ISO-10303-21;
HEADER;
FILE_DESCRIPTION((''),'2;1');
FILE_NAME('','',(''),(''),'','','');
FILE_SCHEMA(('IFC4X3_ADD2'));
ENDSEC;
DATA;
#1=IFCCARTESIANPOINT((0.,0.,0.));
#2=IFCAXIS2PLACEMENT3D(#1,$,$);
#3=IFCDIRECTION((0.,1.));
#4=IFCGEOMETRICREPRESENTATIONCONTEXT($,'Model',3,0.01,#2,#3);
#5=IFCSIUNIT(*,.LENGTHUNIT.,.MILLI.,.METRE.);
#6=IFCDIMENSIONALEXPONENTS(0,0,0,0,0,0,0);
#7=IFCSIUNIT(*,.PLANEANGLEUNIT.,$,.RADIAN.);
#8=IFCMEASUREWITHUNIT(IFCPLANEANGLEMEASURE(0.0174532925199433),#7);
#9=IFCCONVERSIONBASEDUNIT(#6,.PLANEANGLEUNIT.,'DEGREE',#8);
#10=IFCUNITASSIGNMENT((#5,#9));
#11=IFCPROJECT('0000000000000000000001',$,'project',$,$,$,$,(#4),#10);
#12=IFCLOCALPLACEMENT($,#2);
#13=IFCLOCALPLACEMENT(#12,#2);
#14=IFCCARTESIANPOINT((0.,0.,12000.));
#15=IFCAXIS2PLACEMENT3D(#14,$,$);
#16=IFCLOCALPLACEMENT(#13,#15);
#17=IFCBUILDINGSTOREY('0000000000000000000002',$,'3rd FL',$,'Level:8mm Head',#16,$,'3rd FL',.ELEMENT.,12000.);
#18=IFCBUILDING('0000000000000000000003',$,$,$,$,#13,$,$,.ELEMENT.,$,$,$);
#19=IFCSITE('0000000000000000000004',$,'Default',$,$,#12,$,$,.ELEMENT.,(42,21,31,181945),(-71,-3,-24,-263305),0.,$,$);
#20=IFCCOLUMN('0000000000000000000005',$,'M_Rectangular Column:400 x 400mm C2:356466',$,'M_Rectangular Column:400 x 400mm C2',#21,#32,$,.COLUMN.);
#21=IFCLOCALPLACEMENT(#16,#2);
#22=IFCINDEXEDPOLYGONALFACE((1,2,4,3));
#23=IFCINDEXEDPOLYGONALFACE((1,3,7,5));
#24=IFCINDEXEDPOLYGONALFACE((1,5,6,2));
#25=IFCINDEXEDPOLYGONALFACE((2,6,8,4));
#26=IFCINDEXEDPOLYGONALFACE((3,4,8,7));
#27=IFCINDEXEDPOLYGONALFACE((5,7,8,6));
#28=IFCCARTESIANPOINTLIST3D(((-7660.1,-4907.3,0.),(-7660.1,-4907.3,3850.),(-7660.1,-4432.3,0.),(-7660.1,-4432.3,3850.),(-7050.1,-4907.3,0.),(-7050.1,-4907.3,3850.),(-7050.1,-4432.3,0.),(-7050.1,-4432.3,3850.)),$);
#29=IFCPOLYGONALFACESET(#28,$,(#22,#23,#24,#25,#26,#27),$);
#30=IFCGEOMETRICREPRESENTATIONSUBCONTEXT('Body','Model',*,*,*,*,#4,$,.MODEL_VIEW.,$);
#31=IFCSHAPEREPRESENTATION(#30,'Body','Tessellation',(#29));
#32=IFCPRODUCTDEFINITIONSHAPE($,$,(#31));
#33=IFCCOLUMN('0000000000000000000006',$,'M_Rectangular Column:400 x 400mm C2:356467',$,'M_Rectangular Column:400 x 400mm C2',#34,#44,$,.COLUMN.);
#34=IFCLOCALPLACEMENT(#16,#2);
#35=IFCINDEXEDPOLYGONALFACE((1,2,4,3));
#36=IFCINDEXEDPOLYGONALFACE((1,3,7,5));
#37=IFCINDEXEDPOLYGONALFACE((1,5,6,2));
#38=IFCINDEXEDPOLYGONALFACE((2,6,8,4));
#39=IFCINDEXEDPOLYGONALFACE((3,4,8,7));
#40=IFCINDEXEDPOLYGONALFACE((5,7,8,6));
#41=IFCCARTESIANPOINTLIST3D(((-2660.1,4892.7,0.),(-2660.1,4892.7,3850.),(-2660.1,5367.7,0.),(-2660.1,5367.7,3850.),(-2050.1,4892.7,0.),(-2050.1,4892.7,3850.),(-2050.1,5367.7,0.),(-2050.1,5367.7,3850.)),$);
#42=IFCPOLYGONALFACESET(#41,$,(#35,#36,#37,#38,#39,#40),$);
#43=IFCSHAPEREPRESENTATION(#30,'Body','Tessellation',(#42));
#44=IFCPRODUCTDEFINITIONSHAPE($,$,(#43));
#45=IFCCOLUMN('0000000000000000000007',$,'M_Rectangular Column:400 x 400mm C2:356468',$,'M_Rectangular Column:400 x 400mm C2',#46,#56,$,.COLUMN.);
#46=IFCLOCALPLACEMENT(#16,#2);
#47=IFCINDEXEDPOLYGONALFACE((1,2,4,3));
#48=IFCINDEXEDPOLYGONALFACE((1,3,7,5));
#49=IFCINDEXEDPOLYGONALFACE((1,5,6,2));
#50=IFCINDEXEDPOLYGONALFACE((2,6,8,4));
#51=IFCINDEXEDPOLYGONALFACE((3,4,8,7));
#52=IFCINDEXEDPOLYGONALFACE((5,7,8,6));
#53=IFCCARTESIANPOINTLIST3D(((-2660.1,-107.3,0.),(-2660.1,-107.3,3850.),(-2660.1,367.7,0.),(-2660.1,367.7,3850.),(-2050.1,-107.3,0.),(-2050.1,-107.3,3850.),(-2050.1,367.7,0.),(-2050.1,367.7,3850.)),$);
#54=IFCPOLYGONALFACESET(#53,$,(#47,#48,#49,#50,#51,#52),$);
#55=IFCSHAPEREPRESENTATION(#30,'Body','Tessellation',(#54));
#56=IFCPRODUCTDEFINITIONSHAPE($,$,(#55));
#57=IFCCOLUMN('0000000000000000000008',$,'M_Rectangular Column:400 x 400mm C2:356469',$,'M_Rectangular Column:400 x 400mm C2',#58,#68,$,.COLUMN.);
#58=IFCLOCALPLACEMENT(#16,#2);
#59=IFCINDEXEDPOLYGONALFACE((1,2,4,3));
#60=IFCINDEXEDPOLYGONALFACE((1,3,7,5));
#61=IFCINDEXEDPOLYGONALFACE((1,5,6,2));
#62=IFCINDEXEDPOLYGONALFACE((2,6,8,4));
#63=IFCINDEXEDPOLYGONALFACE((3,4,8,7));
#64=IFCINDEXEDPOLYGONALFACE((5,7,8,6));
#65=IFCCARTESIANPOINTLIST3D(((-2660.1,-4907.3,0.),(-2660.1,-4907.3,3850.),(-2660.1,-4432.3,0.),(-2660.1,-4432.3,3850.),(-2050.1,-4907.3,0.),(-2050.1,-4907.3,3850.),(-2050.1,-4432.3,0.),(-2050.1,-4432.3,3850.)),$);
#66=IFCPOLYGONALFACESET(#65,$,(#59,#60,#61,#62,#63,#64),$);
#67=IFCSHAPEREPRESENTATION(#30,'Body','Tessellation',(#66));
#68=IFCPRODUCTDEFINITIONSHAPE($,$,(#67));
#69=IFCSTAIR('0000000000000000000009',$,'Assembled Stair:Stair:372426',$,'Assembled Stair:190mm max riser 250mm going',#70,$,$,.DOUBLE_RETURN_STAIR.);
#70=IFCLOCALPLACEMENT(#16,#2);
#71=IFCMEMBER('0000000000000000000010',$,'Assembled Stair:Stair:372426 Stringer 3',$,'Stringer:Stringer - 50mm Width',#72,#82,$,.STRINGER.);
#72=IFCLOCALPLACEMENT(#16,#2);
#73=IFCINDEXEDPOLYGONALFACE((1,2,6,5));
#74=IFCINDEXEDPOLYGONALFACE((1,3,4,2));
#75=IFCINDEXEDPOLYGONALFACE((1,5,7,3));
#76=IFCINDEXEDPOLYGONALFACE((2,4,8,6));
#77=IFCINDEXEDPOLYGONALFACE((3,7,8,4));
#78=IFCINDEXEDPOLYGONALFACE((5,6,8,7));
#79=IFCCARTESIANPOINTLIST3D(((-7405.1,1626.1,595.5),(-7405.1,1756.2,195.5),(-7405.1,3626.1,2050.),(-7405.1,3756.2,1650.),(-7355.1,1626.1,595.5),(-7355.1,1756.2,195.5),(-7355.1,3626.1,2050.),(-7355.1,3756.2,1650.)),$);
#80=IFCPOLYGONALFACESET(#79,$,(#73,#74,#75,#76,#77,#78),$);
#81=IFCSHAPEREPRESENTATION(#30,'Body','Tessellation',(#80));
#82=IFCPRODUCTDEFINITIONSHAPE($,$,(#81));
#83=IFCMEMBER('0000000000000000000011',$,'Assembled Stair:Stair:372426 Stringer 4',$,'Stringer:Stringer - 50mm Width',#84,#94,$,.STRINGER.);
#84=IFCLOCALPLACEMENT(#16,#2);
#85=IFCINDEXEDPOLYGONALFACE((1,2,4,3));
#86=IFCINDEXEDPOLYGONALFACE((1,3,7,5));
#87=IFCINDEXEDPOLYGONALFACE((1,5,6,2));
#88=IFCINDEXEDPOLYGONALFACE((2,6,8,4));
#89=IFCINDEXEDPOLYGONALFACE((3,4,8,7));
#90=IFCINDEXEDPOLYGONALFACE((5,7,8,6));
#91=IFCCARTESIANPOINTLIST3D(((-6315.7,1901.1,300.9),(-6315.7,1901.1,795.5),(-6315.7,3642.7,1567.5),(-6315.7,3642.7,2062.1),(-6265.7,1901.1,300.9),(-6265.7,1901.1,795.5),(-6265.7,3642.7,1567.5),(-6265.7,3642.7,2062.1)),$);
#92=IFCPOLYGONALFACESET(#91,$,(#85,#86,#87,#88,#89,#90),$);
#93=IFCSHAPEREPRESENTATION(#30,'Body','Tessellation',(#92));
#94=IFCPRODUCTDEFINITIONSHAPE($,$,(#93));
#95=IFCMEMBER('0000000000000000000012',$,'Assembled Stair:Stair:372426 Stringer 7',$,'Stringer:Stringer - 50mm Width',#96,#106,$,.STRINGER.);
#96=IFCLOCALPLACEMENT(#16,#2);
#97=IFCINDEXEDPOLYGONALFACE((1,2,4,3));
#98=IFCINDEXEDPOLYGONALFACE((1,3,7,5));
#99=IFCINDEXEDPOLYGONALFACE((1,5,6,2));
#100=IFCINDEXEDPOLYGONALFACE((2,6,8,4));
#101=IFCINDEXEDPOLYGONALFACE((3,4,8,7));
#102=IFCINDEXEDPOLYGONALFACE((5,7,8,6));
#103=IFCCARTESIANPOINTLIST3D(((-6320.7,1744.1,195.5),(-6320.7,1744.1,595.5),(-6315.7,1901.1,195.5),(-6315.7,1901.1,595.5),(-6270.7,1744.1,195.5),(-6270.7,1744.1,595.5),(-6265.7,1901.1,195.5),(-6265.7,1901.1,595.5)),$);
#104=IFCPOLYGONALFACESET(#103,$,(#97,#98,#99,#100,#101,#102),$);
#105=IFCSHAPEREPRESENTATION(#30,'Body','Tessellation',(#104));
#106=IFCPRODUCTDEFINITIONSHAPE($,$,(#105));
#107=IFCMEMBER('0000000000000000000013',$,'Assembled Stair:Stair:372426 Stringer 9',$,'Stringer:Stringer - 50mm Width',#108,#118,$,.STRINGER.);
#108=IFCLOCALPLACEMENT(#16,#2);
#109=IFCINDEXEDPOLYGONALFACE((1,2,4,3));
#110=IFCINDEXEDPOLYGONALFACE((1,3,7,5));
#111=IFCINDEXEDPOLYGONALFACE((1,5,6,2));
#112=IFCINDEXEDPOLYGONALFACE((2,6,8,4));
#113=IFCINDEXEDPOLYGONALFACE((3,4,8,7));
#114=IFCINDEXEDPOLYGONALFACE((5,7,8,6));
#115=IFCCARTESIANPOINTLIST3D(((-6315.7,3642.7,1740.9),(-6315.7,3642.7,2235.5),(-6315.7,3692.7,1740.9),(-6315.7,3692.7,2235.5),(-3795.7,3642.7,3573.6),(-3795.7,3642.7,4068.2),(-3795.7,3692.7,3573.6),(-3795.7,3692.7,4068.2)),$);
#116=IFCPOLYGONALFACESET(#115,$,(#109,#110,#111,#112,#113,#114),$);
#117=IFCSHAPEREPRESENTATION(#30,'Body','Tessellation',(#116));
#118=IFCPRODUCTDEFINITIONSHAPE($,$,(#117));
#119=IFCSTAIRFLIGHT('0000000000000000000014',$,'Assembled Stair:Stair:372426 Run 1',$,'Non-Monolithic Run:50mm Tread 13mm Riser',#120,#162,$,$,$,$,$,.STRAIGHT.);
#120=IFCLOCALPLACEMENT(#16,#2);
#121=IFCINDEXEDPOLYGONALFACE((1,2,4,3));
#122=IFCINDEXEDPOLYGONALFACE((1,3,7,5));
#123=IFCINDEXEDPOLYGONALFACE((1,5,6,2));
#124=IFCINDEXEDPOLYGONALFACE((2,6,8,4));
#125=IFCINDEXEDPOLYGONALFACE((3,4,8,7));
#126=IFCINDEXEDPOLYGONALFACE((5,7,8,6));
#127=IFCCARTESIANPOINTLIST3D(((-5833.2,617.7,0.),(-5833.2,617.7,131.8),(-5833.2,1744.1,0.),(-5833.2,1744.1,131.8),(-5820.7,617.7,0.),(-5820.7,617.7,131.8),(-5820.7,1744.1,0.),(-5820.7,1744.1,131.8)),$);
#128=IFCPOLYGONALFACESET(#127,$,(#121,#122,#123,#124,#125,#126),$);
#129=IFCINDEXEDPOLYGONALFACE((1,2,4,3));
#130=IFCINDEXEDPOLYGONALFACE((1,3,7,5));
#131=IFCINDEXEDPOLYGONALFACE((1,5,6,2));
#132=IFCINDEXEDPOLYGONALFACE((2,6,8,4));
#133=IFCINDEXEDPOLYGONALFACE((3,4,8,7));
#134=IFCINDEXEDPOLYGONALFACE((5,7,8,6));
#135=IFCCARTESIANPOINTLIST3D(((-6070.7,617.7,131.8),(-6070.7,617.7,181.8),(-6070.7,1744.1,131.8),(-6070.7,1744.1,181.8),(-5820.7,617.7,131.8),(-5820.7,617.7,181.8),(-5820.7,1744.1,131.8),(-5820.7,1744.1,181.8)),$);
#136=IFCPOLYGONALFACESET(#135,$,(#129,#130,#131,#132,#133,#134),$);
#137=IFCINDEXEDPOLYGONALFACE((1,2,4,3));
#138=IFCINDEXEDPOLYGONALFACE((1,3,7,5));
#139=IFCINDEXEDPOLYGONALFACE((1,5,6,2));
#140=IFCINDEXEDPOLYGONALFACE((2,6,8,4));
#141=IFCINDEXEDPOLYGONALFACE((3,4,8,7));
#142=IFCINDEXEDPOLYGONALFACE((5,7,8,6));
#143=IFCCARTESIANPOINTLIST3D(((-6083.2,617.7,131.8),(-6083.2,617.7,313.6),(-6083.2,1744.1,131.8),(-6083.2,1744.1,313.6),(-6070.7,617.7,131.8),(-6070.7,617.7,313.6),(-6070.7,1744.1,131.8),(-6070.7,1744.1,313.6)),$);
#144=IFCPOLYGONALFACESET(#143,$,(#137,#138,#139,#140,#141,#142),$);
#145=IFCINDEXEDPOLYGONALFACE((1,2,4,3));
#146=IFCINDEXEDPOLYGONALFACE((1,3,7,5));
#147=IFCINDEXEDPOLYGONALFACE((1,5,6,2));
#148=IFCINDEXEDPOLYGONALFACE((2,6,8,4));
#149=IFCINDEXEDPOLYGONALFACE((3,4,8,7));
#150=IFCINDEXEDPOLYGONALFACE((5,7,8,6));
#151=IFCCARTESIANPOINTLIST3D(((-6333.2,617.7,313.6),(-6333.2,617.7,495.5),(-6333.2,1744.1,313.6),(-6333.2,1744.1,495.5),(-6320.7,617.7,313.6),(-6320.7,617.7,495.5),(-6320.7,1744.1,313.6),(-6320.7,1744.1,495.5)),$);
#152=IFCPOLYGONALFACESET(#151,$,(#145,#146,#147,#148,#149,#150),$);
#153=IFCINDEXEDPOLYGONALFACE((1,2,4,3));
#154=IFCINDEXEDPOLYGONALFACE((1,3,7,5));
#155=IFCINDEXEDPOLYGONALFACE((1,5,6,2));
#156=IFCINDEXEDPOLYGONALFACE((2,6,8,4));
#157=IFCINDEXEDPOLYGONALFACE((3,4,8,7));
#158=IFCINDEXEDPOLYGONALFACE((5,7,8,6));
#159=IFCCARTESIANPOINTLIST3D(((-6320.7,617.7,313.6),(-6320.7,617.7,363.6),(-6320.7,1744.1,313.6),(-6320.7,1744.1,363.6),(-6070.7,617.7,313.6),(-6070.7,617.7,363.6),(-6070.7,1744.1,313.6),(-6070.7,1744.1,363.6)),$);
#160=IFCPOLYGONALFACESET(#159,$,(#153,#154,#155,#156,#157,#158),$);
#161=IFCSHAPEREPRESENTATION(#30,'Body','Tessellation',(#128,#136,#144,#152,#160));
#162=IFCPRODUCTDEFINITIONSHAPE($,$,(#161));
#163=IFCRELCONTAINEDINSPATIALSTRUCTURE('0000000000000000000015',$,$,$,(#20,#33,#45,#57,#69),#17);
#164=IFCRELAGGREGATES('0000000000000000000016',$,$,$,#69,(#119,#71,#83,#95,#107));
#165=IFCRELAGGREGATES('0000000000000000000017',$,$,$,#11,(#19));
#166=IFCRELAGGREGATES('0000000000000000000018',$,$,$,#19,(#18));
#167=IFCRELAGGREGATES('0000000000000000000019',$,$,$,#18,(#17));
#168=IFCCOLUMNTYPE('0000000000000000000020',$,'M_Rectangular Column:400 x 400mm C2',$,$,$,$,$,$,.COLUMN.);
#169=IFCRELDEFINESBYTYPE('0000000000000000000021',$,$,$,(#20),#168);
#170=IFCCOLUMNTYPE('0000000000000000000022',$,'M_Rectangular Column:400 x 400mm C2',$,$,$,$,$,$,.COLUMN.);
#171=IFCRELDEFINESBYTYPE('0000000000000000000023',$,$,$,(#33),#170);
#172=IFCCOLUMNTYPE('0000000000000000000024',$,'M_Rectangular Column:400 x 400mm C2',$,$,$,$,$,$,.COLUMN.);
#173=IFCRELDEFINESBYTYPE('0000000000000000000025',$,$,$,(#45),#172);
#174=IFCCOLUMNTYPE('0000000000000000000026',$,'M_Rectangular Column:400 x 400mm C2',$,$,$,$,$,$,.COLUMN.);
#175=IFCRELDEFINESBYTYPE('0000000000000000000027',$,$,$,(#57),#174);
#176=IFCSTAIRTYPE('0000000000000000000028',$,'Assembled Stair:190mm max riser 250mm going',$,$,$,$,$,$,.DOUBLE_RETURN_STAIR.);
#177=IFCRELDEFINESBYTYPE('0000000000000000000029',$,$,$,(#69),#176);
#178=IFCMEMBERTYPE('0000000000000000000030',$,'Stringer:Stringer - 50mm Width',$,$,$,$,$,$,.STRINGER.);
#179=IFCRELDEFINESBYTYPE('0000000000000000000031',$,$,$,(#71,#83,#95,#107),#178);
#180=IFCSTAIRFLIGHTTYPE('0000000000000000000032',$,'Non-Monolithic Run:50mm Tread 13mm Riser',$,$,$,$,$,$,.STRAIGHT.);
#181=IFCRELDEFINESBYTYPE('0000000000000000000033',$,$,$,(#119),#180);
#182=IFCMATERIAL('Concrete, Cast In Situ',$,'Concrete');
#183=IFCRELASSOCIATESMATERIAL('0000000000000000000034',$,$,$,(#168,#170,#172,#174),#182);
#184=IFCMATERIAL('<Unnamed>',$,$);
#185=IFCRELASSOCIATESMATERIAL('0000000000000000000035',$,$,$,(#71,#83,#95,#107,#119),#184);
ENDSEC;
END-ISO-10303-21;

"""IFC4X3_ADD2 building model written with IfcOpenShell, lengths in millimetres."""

from ifc_helpers import new_model, entity, si_unit, converted_unit, direction, frame, frame_2d, origin, origin_2d_with_axis, place, context, subcontext, project, spatial, polyline, rectangle, outline, extrude, source, transform, mapped, material, material_profile, profile_set, type_object, type_shapes, element, aggregate, save


model = new_model("IFC4X3_ADD2")

# Units and contexts
model_context = context("Model", 3, precision=0.01, world=origin(), true_north=direction((0.0, 1.0)))
body_context = subcontext(model_context, "Body", "Model", "MODEL_VIEW")
ifc_project = project(units=[si_unit("LENGTHUNIT", "METRE", prefix="MILLI"), converted_unit("PLANEANGLEUNIT", "DEGREE", entity("IfcPlaneAngleMeasure", 0.0174532925199433), si_unit("PLANEANGLEUNIT", "RADIAN"), dimensions=[0, 0, 0, 0, 0, 0, 0])], contexts=[model_context])

# Site, building, storey
site_placement = place(None, origin())
site = spatial("IfcSite", under=ifc_project, at=site_placement, Name="Default", CompositionType="ELEMENT", RefLatitude=(42, 21, 31, 181945), RefLongitude=(-71, -3, -24, -263305), RefElevation=0.0)
building_placement = place(site_placement, origin())
building = spatial("IfcBuilding", under=site, at=building_placement, CompositionType="ELEMENT")
storey_placement = place(building_placement, frame((0.0, 0.0, 12000.0)))
storey = spatial("IfcBuildingStorey", under=building, at=storey_placement, Name="3rd FL", ObjectType="Level:8mm Head", LongName="3rd FL", CompositionType="ELEMENT", Elevation=12000.0)

# Columns
ifc_material_1 = material(Name="Concrete, Cast In Situ", Category="Concrete")
ifc_material_profile_1 = material_profile(ifc_material_1, rectangle(XDim=610.0, YDim=475.0, at=origin_2d_with_axis()), Name="400 x 400mm C2")
ifc_profile_set_1 = profile_set([ifc_material_profile_1], Name="400 x 400mm C2")
column_type_1 = type_object("IfcColumnType", Name="M_Rectangular Column:400 x 400mm C2", PredefinedType="COLUMN", material=ifc_profile_set_1)
shared_shape_1 = source(origin(), body_context, "Body", "SweptSolid", [
    extrude(rectangle(XDim=610.0, YDim=475.0, at=frame_2d((0.0, 0.0), x_axis=(1.0, 0.0))), frame((-7355.1, -4669.8, 12000.0), z_axis=(0.0, 0.0, 1.0), x_axis=(-1.0, 0.0, 0.0)), (0.0, 0.0, 1.0), 3850.0),
])
type_shapes(column_type_1, [shared_shape_1])
column_1_placement = place(storey_placement, frame((0.0, 0.0, -12000.0)))
element("IfcColumn", 1, at=column_1_placement, inside=storey, type_object=column_type_1, Name="M_Rectangular Column:400 x 400mm C2:356466", ObjectType="M_Rectangular Column:400 x 400mm C2", PredefinedType="COLUMN", context=body_context, shape_type="MappedRepresentation", body=[
    mapped(shared_shape_1, transform((0.0, 0.0, 0.0), scale=1.0)),
])
column_type_2 = type_object("IfcColumnType", Name="M_Rectangular Column:400 x 400mm C2", PredefinedType="COLUMN", material=ifc_profile_set_1)
shared_shape_2 = source(origin(), body_context, "Body", "SweptSolid", [
    extrude(rectangle(XDim=610.0, YDim=475.0, at=frame_2d((0.0, 0.0), x_axis=(1.0, 0.0))), frame((-2355.1, 5130.2, 12000.0), z_axis=(0.0, 0.0, 1.0), x_axis=(-1.0, 0.0, 0.0)), (0.0, 0.0, 1.0), 3850.0),
])
type_shapes(column_type_2, [shared_shape_2])
column_2_placement = place(storey_placement, frame((0.0, 0.0, -12000.0)))
element("IfcColumn", 2, at=column_2_placement, inside=storey, type_object=column_type_2, Name="M_Rectangular Column:400 x 400mm C2:356467", ObjectType="M_Rectangular Column:400 x 400mm C2", PredefinedType="COLUMN", context=body_context, shape_type="MappedRepresentation", body=[
    mapped(shared_shape_2, transform((0.0, 0.0, 0.0), scale=1.0)),
])
column_type_3 = type_object("IfcColumnType", Name="M_Rectangular Column:400 x 400mm C2", PredefinedType="COLUMN", material=ifc_profile_set_1)
shared_shape_3 = source(origin(), body_context, "Body", "SweptSolid", [
    extrude(rectangle(XDim=610.0, YDim=475.0, at=frame_2d((0.0, 0.0), x_axis=(1.0, 0.0))), frame((-2355.1, 130.2, 12000.0), z_axis=(0.0, 0.0, 1.0), x_axis=(-1.0, 0.0, 0.0)), (0.0, 0.0, 1.0), 3850.0),
])
type_shapes(column_type_3, [shared_shape_3])
column_3_placement = place(storey_placement, frame((0.0, 0.0, -12000.0)))
element("IfcColumn", 3, at=column_3_placement, inside=storey, type_object=column_type_3, Name="M_Rectangular Column:400 x 400mm C2:356468", ObjectType="M_Rectangular Column:400 x 400mm C2", PredefinedType="COLUMN", context=body_context, shape_type="MappedRepresentation", body=[
    mapped(shared_shape_3, transform((0.0, 0.0, 0.0), scale=1.0)),
])
column_type_4 = type_object("IfcColumnType", Name="M_Rectangular Column:400 x 400mm C2", PredefinedType="COLUMN", material=ifc_profile_set_1)
shared_shape_4 = source(origin(), body_context, "Body", "SweptSolid", [
    extrude(rectangle(XDim=610.0, YDim=475.0, at=frame_2d((0.0, 0.0), x_axis=(1.0, 0.0))), frame((-2355.1, -4669.8, 12000.0), z_axis=(0.0, 0.0, 1.0), x_axis=(-1.0, 0.0, 0.0)), (0.0, 0.0, 1.0), 3850.0),
])
type_shapes(column_type_4, [shared_shape_4])
column_4_placement = place(storey_placement, frame((0.0, 0.0, -12000.0)))
element("IfcColumn", 4, at=column_4_placement, inside=storey, type_object=column_type_4, Name="M_Rectangular Column:400 x 400mm C2:356469", ObjectType="M_Rectangular Column:400 x 400mm C2", PredefinedType="COLUMN", context=body_context, shape_type="MappedRepresentation", body=[
    mapped(shared_shape_4, transform((0.0, 0.0, 0.0), scale=1.0)),
])

# Stair, members
stair_type = type_object("IfcStairType", Name="Assembled Stair:190mm max riser 250mm going", PredefinedType="DOUBLE_RETURN_STAIR")
stair_placement = place(storey_placement, origin())
stair = element("IfcStair", 5, at=stair_placement, inside=storey, type_object=stair_type, Name="Assembled Stair:Stair:372426", ObjectType="Assembled Stair:190mm max riser 250mm going", PredefinedType="DOUBLE_RETURN_STAIR")
ifc_material_2 = material(Name="<Unnamed>")
member_type = type_object("IfcMemberType", Name="Stringer:Stringer - 50mm Width", PredefinedType="STRINGER")
member_1_placement = place(stair_placement, frame((-7405.1, 1626.1, 195.5)))
member_1 = element("IfcMember", 6, at=member_1_placement, type_object=member_type, material=ifc_material_2, Name="Assembled Stair:Stair:372426 Stringer 3", ObjectType="Stringer:Stringer - 50mm Width", PredefinedType="STRINGER", context=body_context, shape_type="SweptSolid", body=[
    extrude(outline(polyline([(-1301.5, -200.0), (1171.5, -200.0), (1301.5, 200.0), (-1171.5, 200.0), (-1301.5, -200.0)])), frame((0.0, 1065.0, 927.3), z_axis=(1.0, 0.0, 0.0), x_axis=(0.0, 0.808736, 0.588172)), (0.0, 0.0, 1.0), 50.0),
])
member_2_placement = place(stair_placement, frame((-6315.7, 1901.1, 300.9)))
member_2 = element("IfcMember", 7, at=member_2_placement, type_object=member_type, material=ifc_material_2, Name="Assembled Stair:Stair:372426 Stringer 4", ObjectType="Stringer:Stringer - 50mm Width", PredefinedType="STRINGER", context=body_context, shape_type="SweptSolid", body=[
    extrude(outline(polyline([(-1222.2, -200.0), (931.3, -200.0), (1222.2, 200.0), (-931.3, 200.0), (-1222.2, -200.0)])), frame((0.0, 870.8, 880.6), z_axis=(1.0, 0.0, 0.0), x_axis=(0.0, 0.808736, 0.588172)), (0.0, 0.0, 1.0), 50.0),
])
member_3_placement = place(stair_placement, frame((-6320.7, 1744.1, 195.5)))
member_3 = element("IfcMember", 8, at=member_3_placement, type_object=member_type, material=ifc_material_2, Name="Assembled Stair:Stair:372426 Stringer 7", ObjectType="Stringer:Stringer - 50mm Width", PredefinedType="STRINGER", context=body_context, shape_type="SweptSolid", body=[
    extrude(outline(polyline([(-77.7, -25.0), (79.3, -25.0), (77.7, 25.0), (-79.3, 25.0), (-77.7, -25.0)])), frame((27.5, 78.5, 0.0), z_axis=(0.0, 0.0, 1.0), x_axis=(0.031792, 0.999495, 0.0)), (0.0, 0.0, 1.0), 400.0),
])
member_4_placement = place(stair_placement, frame((-6315.7, 3642.7, 1740.9)))
member_4 = element("IfcMember", 9, at=member_4_placement, type_object=member_type, material=ifc_material_2, Name="Assembled Stair:Stair:372426 Stringer 9", ObjectType="Stringer:Stringer - 50mm Width", PredefinedType="STRINGER", context=body_context, shape_type="SweptSolid", body=[
    extrude(outline(polyline([(-1412.6, -200.0), (1703.5, -200.0), (1412.6, 200.0), (-1703.5, 200.0), (-1412.6, -200.0)])), frame((1260.0, 0.0, 1163.7), z_axis=(0.0, 1.0, 0.0), x_axis=(0.808736, 0.0, 0.588172)), (0.0, 0.0, 1.0), 50.0),
])

# Stair flight
stair_flight_type = type_object("IfcStairFlightType", Name="Non-Monolithic Run:50mm Tread 13mm Riser", PredefinedType="STRAIGHT")
stair_flight_1_placement = place(stair_placement, frame((-6333.2, 617.7, 0.0)))
stair_flight_1 = element("IfcStairFlight", 10, at=stair_flight_1_placement, type_object=stair_flight_type, material=ifc_material_2, Name="Assembled Stair:Stair:372426 Run 1", ObjectType="Non-Monolithic Run:50mm Tread 13mm Riser", PredefinedType="STRAIGHT", context=body_context, shape_type="SweptSolid", body=[
    extrude(rectangle(XDim=1126.4, YDim=12.5, at=origin_2d_with_axis()), frame((506.3, 563.2, 0.0), z_axis=(0.0, 0.0, 1.0), x_axis=(0.0, -1.0, 0.0)), (0.0, 0.0, 1.0), 131.8),
    extrude(rectangle(XDim=250.0, YDim=1126.4, at=origin_2d_with_axis()), frame((387.5, 563.2, 131.8)), (0.0, 0.0, 1.0), 50.0),
    extrude(rectangle(XDim=1126.4, YDim=12.5, at=frame_2d((0.0, 0.0), x_axis=(1.0, 0.0))), frame((256.3, 563.2, 131.8), z_axis=(0.0, 0.0, 1.0), x_axis=(0.0, -1.0, 0.0)), (0.0, 0.0, 1.0), 181.8),
    extrude(rectangle(XDim=1126.4, YDim=12.5, at=frame_2d((0.0, 0.0), x_axis=(1.0, 0.0))), frame((6.3, 563.2, 313.6), z_axis=(0.0, 0.0, 1.0), x_axis=(0.0, -1.0, 0.0)), (0.0, 0.0, 1.0), 181.8),
    extrude(rectangle(XDim=250.0, YDim=1126.4, at=frame_2d((0.0, 0.0), x_axis=(1.0, 0.0))), frame((137.5, 563.2, 313.6)), (0.0, 0.0, 1.0), 50.0),
])
aggregate(stair, [stair_flight_1, member_1, member_2, member_3, member_4])

save(model, "model.ifc")
